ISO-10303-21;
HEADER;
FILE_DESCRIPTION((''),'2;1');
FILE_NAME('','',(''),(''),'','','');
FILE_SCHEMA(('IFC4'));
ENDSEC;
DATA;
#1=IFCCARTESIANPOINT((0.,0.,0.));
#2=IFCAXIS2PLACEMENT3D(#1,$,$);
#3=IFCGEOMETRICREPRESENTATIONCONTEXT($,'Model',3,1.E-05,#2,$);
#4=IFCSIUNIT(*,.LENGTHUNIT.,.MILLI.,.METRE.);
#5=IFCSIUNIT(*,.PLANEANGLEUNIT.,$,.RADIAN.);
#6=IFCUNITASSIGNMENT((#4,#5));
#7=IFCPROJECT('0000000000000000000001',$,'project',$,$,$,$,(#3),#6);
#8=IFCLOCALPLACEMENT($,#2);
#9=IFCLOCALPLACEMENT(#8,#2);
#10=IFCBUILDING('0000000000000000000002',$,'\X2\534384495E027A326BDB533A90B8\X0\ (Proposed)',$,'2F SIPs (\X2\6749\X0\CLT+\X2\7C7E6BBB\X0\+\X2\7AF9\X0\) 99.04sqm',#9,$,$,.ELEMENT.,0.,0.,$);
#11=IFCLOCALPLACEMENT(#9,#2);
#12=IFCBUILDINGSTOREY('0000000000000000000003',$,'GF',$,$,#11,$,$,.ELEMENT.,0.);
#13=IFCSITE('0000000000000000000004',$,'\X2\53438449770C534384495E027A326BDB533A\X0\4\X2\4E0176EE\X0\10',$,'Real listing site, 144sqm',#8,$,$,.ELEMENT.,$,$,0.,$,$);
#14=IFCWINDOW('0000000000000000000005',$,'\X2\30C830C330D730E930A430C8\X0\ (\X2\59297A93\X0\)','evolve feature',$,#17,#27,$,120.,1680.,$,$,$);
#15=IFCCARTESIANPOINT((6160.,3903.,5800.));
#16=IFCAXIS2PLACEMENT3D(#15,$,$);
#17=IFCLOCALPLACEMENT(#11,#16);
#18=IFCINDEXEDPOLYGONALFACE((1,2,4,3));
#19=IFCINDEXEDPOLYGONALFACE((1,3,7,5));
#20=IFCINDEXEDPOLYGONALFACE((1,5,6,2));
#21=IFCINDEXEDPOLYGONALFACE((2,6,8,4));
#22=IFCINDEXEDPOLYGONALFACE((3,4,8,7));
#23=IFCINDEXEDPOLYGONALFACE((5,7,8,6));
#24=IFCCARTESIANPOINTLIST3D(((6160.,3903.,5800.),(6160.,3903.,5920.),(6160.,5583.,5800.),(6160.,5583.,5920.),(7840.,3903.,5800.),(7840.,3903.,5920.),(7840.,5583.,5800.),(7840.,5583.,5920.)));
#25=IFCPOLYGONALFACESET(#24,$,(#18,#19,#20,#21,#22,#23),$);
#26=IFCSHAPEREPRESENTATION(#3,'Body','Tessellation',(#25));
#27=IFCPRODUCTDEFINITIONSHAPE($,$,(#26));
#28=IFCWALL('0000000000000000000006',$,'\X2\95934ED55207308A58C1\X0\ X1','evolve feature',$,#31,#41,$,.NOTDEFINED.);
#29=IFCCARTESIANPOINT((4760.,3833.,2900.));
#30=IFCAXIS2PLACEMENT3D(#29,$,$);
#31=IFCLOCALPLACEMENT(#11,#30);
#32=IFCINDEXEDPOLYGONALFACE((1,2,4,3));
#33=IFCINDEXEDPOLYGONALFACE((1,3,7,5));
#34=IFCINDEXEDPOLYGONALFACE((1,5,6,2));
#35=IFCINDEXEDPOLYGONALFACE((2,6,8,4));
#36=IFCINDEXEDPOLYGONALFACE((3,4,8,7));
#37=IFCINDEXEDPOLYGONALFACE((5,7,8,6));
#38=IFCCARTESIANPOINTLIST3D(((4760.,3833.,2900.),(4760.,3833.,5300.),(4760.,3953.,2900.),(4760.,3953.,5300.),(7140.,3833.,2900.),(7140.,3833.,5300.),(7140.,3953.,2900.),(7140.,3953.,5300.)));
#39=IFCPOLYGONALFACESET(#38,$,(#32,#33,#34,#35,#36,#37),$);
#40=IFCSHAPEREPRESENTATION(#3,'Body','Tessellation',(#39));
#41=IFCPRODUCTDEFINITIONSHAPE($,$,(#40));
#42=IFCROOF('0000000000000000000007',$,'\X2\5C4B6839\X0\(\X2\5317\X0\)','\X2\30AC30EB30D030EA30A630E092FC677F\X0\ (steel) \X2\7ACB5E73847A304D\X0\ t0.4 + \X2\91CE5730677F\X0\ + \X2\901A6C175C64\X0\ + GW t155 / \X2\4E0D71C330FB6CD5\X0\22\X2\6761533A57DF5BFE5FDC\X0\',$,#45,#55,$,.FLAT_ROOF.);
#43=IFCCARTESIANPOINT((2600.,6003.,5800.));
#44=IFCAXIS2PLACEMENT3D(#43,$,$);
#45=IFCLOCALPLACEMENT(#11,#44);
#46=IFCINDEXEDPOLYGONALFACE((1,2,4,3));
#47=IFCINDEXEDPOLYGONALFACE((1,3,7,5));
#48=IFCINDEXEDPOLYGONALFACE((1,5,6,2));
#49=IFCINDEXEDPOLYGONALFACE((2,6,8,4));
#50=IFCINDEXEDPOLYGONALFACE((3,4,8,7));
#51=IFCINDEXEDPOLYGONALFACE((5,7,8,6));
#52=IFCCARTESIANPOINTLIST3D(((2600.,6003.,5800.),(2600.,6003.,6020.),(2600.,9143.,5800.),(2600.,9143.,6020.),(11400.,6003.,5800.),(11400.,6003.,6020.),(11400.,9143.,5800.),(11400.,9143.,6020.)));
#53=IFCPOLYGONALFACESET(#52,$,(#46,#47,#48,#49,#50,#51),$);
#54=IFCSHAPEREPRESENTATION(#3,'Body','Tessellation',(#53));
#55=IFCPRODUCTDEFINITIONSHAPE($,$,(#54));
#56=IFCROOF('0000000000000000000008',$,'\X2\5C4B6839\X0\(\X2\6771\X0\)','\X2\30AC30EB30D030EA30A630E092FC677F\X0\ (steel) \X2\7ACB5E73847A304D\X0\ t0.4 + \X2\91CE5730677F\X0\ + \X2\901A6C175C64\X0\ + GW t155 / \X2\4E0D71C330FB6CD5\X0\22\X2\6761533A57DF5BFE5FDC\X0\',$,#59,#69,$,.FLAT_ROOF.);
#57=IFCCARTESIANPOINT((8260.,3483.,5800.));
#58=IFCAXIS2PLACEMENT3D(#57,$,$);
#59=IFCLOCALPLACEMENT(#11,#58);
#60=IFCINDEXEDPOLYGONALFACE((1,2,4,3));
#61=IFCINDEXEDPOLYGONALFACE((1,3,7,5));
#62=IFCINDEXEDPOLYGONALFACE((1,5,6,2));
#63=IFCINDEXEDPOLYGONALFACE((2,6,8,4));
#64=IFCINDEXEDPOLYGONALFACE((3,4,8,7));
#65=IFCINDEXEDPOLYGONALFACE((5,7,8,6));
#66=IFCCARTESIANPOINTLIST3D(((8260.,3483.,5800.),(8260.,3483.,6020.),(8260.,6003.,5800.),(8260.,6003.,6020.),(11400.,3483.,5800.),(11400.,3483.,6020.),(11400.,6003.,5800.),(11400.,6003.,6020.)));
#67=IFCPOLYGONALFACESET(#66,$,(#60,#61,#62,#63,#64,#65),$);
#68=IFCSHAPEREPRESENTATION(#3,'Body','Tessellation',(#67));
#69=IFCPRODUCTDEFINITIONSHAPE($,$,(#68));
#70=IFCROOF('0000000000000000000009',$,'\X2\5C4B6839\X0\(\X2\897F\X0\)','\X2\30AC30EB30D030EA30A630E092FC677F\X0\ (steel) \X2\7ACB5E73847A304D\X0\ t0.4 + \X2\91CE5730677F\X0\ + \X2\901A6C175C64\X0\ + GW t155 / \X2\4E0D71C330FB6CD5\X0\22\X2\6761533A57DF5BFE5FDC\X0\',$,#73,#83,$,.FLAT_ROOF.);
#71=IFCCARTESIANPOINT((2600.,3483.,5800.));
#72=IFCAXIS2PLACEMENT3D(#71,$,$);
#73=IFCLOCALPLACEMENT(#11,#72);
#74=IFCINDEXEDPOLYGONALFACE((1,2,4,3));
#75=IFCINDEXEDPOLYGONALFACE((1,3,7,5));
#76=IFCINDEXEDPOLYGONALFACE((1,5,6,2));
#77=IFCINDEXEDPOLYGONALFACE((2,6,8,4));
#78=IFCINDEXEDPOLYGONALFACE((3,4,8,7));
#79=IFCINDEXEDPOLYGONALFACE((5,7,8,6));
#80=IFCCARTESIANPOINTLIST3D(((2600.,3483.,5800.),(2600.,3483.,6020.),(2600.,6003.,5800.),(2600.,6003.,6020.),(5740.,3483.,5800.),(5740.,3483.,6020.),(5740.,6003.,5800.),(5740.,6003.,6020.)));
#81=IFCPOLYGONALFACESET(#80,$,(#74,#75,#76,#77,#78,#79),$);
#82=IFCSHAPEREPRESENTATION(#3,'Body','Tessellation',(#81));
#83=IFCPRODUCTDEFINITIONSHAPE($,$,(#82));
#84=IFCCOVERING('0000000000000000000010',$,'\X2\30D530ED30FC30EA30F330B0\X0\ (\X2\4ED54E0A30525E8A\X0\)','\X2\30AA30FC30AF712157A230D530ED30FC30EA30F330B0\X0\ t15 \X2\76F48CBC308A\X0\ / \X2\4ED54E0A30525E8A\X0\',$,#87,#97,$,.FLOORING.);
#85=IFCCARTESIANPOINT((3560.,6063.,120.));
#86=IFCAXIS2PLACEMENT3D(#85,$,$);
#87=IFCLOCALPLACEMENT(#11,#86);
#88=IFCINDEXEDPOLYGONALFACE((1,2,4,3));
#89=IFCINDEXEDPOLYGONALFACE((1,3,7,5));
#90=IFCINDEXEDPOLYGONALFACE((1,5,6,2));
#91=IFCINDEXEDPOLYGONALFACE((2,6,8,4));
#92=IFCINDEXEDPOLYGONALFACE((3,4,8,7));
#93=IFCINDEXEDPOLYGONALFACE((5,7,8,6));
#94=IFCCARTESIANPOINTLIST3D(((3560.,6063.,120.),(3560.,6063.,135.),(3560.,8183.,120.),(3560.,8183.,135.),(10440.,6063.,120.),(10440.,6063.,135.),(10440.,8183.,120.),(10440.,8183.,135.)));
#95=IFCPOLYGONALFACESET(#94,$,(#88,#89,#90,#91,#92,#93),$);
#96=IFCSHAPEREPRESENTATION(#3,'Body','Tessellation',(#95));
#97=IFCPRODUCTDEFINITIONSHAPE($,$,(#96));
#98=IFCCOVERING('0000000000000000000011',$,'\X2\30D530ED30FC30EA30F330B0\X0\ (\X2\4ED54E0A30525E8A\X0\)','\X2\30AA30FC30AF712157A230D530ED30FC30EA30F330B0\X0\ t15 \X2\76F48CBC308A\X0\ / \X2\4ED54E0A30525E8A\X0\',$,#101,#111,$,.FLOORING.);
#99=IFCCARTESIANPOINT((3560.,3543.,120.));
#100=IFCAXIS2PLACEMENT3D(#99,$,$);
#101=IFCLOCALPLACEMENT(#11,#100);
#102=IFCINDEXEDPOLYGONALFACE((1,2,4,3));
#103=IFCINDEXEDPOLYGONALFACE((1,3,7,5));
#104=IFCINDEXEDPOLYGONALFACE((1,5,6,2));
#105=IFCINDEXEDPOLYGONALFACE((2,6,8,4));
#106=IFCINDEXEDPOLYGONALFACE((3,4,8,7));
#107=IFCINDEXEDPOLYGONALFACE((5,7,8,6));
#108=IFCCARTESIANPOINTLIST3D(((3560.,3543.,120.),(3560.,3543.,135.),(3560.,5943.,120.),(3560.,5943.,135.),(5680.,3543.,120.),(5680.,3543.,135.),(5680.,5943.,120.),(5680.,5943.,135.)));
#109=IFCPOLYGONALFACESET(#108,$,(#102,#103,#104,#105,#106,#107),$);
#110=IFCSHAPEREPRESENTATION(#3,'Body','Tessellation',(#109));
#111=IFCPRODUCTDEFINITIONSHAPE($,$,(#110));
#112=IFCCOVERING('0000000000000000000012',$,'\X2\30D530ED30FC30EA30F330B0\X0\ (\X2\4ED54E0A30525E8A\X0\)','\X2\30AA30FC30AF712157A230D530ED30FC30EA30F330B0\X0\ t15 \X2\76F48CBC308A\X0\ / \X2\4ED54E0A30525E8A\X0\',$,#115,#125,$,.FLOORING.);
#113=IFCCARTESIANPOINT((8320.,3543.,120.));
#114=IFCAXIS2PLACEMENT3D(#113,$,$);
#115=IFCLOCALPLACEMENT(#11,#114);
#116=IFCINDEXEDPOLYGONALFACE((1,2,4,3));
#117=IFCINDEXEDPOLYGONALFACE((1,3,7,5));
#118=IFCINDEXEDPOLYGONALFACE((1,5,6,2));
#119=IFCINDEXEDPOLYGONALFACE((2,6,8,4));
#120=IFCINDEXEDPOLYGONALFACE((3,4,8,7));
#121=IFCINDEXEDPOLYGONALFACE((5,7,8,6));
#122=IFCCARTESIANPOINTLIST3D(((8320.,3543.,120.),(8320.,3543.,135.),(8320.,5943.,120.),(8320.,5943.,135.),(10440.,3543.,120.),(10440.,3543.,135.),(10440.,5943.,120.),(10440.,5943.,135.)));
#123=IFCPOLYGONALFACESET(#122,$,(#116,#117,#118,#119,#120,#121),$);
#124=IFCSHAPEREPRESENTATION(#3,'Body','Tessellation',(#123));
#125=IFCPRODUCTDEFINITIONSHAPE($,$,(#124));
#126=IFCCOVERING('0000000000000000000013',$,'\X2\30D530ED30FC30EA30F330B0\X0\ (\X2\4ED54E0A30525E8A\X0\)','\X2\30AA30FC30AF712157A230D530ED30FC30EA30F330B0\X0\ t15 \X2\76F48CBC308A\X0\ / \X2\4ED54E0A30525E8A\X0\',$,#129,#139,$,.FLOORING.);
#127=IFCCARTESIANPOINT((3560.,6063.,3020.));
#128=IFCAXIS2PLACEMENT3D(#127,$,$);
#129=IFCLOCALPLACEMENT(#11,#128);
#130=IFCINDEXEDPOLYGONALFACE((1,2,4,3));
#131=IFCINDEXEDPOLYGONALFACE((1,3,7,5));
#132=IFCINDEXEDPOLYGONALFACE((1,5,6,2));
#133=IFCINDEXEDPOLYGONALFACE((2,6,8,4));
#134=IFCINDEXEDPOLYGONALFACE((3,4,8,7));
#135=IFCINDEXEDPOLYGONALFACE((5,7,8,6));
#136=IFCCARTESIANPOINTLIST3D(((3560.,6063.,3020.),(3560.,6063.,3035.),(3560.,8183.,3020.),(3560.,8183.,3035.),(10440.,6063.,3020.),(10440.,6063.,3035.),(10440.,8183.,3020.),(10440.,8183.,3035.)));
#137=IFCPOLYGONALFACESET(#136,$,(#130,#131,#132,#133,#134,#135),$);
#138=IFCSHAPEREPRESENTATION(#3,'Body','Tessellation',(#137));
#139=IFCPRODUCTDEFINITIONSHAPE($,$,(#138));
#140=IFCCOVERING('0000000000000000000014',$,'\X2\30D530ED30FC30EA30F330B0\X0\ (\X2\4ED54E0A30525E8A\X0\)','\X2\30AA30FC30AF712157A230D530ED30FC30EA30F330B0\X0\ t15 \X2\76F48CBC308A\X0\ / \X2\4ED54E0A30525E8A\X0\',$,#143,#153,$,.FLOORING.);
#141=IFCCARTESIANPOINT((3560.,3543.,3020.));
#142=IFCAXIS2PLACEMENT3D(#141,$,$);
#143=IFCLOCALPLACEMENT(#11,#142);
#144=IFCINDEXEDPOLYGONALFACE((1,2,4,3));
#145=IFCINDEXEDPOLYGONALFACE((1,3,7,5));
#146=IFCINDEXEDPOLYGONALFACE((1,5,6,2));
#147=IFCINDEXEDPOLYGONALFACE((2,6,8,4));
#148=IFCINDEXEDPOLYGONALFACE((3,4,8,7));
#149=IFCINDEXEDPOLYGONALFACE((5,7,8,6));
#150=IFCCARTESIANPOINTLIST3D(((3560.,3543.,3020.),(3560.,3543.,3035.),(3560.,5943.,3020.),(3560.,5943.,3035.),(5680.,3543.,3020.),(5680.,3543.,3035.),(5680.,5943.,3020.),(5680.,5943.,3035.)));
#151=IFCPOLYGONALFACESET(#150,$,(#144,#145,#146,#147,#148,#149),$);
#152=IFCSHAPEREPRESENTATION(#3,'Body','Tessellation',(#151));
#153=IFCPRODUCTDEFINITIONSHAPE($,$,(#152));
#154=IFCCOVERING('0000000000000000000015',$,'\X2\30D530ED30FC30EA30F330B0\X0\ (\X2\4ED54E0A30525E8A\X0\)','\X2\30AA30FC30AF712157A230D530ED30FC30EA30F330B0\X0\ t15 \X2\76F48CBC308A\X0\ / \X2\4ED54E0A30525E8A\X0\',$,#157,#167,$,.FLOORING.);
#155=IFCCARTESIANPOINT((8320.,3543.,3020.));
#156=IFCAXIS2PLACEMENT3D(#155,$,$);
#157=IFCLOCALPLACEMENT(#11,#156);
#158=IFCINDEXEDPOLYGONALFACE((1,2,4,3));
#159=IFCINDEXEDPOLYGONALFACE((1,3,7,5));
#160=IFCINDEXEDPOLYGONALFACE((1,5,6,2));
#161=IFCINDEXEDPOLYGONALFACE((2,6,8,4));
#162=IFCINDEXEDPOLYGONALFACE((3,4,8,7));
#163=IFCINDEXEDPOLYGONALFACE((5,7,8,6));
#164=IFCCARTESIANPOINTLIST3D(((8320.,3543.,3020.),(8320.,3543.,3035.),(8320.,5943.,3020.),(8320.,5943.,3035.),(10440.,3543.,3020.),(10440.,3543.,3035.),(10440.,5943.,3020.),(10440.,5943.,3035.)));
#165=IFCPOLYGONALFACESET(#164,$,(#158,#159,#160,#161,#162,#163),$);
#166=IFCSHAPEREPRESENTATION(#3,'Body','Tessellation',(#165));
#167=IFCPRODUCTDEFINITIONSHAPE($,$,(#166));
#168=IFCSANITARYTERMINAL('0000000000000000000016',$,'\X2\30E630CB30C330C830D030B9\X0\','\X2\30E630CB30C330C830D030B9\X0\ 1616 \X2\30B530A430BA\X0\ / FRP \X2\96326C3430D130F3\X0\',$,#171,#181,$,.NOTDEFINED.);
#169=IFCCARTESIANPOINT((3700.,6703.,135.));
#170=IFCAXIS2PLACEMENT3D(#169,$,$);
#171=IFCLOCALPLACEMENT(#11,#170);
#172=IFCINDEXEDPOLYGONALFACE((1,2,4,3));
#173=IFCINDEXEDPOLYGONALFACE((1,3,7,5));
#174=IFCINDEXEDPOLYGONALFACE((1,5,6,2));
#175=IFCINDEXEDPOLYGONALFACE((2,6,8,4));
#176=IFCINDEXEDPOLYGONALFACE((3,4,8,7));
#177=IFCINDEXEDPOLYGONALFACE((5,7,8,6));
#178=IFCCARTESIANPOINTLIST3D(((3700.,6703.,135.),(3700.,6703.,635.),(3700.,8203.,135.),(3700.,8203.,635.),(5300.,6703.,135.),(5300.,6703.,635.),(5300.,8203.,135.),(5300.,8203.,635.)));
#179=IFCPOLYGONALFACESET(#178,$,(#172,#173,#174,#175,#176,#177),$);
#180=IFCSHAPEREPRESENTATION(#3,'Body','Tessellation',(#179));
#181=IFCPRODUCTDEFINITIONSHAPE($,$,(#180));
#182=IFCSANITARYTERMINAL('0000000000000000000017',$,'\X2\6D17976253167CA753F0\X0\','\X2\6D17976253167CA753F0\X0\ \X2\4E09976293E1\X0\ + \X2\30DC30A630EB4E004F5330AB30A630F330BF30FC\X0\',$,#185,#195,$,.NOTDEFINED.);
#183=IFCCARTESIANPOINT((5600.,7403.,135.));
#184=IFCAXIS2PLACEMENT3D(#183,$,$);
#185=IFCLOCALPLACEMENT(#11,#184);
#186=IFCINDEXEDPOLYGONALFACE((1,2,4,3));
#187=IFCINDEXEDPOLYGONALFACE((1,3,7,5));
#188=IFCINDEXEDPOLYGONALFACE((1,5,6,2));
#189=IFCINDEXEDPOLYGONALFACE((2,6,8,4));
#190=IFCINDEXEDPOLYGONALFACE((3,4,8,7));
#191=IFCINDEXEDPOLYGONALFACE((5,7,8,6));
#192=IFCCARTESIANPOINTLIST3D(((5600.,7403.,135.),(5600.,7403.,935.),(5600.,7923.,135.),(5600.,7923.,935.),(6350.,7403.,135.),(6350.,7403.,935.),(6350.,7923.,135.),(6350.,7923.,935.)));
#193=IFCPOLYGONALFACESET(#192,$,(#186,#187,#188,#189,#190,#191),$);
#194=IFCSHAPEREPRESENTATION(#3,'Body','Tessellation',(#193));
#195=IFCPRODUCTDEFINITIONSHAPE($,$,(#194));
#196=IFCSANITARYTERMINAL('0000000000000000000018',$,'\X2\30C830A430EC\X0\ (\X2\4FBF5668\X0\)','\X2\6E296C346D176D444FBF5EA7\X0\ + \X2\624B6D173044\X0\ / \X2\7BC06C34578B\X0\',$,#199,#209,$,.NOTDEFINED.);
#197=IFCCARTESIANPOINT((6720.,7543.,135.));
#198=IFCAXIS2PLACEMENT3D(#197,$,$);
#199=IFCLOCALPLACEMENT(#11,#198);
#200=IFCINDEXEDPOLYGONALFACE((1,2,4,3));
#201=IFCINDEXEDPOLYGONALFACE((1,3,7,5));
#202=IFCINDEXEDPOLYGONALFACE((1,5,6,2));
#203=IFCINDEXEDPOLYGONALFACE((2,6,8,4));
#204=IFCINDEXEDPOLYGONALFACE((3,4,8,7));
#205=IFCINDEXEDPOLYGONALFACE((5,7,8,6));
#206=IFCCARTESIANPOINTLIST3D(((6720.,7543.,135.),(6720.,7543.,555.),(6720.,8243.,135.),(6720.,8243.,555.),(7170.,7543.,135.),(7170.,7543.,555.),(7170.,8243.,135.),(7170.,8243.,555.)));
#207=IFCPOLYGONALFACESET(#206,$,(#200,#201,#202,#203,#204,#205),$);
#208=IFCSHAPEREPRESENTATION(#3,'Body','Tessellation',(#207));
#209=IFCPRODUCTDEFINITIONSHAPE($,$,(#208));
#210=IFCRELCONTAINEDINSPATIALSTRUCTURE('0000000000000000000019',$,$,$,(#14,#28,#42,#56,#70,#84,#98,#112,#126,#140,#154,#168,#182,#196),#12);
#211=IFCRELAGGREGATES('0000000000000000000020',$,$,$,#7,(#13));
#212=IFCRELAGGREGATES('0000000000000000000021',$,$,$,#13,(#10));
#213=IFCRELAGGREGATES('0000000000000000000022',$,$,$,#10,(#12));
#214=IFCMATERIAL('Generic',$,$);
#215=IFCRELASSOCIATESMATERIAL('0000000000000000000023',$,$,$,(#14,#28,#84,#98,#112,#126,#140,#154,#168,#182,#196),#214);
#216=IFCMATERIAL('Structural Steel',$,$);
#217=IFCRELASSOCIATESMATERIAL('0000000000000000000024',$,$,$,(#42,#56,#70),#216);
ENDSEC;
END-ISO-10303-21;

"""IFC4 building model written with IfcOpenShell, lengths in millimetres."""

from ifc_helpers import new_model, si_unit, frame, frame_2d, origin, place, context, project, spatial, rectangle, extrude, material, element, save


model = new_model("IFC4")

# Units and contexts
model_context = context("Model", 3, precision=1e-05, world=origin())
ifc_project = project(units=[si_unit("LENGTHUNIT", "METRE", prefix="MILLI"), si_unit("PLANEANGLEUNIT", "RADIAN")], contexts=[model_context])

# Site, building, storey
site_placement = place(None, origin())
site = spatial("IfcSite", under=ifc_project, at=site_placement, Name="千葉県千葉市稲毛区4丁目10", ObjectType="Real listing site, 144sqm", CompositionType="ELEMENT", RefElevation=0.0)
building_placement = place(site_placement, origin())
building = spatial("IfcBuilding", under=site, at=building_placement, Name="千葉市稲毛区邸 (Proposed)", ObjectType="2F SIPs (杉CLT+籾殻+竹) 99.04sqm", CompositionType="ELEMENT", ElevationOfRefHeight=0.0, ElevationOfTerrain=0.0)
storey_placement = place(building_placement, origin())
storey = spatial("IfcBuildingStorey", under=building, at=storey_placement, Name="GF", CompositionType="ELEMENT", Elevation=0.0)

# Window
ifc_material_1 = material(Name="Generic")
window_1_placement = place(storey_placement, frame((6160.0, 3903.0, 5800.0)))
element("IfcWindow", 1, at=window_1_placement, inside=storey, material=ifc_material_1, Name="トップライト (天窓)", Description="evolve feature", OverallHeight=120.0, OverallWidth=1680.0, context=model_context, shape_type="SweptSolid", body=[
    extrude(rectangle(XDim=1680.0, YDim=1680.0, at=frame_2d((840.0, 840.0))), frame((6160.0, 3903.0, 5800.0)), (0.0, 0.0, 1.0), 120.0),
])

# Wall
wall_1_placement = place(storey_placement, frame((4760.0, 3833.0, 2900.0)))
element("IfcWall", 2, at=wall_1_placement, inside=storey, material=ifc_material_1, Name="間仕切り壁 X1", Description="evolve feature", PredefinedType="NOTDEFINED", context=model_context, shape_type="SweptSolid", body=[
    extrude(rectangle(XDim=2380.0, YDim=120.0, at=frame_2d((1190.0, 60.0))), frame((4760.0, 3833.0, 2900.0)), (0.0, 0.0, 1.0), 2400.0),
])

# Roofs
ifc_material_2 = material(Name="Structural Steel")
roof_1_placement = place(storey_placement, frame((2600.0, 6003.0, 5800.0)))
element("IfcRoof", 3, at=roof_1_placement, inside=storey, material=ifc_material_2, Name="屋根(北)", Description="ガルバリウム鋼板 (steel) 立平葺き t0.4 + 野地板 + 通気層 + GW t155 / 不燃・法22条区域対応", PredefinedType="FLAT_ROOF", context=model_context, shape_type="SweptSolid", body=[
    extrude(rectangle(XDim=8800.0, YDim=3140.0, at=frame_2d((4400.0, 1570.0))), frame((2600.0, 6003.0, 5800.0)), (0.0, 0.0, 1.0), 220.0),
])
roof_2_placement = place(storey_placement, frame((8260.0, 3483.0, 5800.0)))
element("IfcRoof", 4, at=roof_2_placement, inside=storey, material=ifc_material_2, Name="屋根(東)", Description="ガルバリウム鋼板 (steel) 立平葺き t0.4 + 野地板 + 通気層 + GW t155 / 不燃・法22条区域対応", PredefinedType="FLAT_ROOF", context=model_context, shape_type="SweptSolid", body=[
    extrude(rectangle(XDim=3140.0, YDim=2520.0, at=frame_2d((1570.0, 1260.0))), frame((8260.0, 3483.0, 5800.0)), (0.0, 0.0, 1.0), 220.0),
])
roof_3_placement = place(storey_placement, frame((2600.0, 3483.0, 5800.0)))
element("IfcRoof", 5, at=roof_3_placement, inside=storey, material=ifc_material_2, Name="屋根(西)", Description="ガルバリウム鋼板 (steel) 立平葺き t0.4 + 野地板 + 通気層 + GW t155 / 不燃・法22条区域対応", PredefinedType="FLAT_ROOF", context=model_context, shape_type="SweptSolid", body=[
    extrude(rectangle(XDim=3140.0, YDim=2520.0, at=frame_2d((1570.0, 1260.0))), frame((2600.0, 3483.0, 5800.0)), (0.0, 0.0, 1.0), 220.0),
])

# Coverings
covering_1_placement = place(storey_placement, frame((3560.0, 6063.0, 120.0)))
element("IfcCovering", 6, at=covering_1_placement, inside=storey, material=ifc_material_1, Name="フローリング (仕上げ床)", Description="オーク無垢フローリング t15 直貼り / 仕上げ床", PredefinedType="FLOORING", context=model_context, shape_type="SweptSolid", body=[
    extrude(rectangle(XDim=6880.0, YDim=2120.0, at=frame_2d((3440.0, 1060.0))), frame((3560.0, 6063.0, 120.0)), (0.0, 0.0, 1.0), 15.0),
])
covering_2_placement = place(storey_placement, frame((3560.0, 3543.0, 120.0)))
element("IfcCovering", 7, at=covering_2_placement, inside=storey, material=ifc_material_1, Name="フローリング (仕上げ床)", Description="オーク無垢フローリング t15 直貼り / 仕上げ床", PredefinedType="FLOORING", context=model_context, shape_type="SweptSolid", body=[
    extrude(rectangle(XDim=2120.0, YDim=2400.0, at=frame_2d((1060.0, 1200.0))), frame((3560.0, 3543.0, 120.0)), (0.0, 0.0, 1.0), 15.0),
])
covering_3_placement = place(storey_placement, frame((8320.0, 3543.0, 120.0)))
element("IfcCovering", 8, at=covering_3_placement, inside=storey, material=ifc_material_1, Name="フローリング (仕上げ床)", Description="オーク無垢フローリング t15 直貼り / 仕上げ床", PredefinedType="FLOORING", context=model_context, shape_type="SweptSolid", body=[
    extrude(rectangle(XDim=2120.0, YDim=2400.0, at=frame_2d((1060.0, 1200.0))), frame((8320.0, 3543.0, 120.0)), (0.0, 0.0, 1.0), 15.0),
])
covering_4_placement = place(storey_placement, frame((3560.0, 6063.0, 3020.0)))
element("IfcCovering", 9, at=covering_4_placement, inside=storey, material=ifc_material_1, Name="フローリング (仕上げ床)", Description="オーク無垢フローリング t15 直貼り / 仕上げ床", PredefinedType="FLOORING", context=model_context, shape_type="SweptSolid", body=[
    extrude(rectangle(XDim=6880.0, YDim=2120.0, at=frame_2d((3440.0, 1060.0))), frame((3560.0, 6063.0, 3020.0)), (0.0, 0.0, 1.0), 15.0),
])
covering_5_placement = place(storey_placement, frame((3560.0, 3543.0, 3020.0)))
element("IfcCovering", 10, at=covering_5_placement, inside=storey, material=ifc_material_1, Name="フローリング (仕上げ床)", Description="オーク無垢フローリング t15 直貼り / 仕上げ床", PredefinedType="FLOORING", context=model_context, shape_type="SweptSolid", body=[
    extrude(rectangle(XDim=2120.0, YDim=2400.0, at=frame_2d((1060.0, 1200.0))), frame((3560.0, 3543.0, 3020.0)), (0.0, 0.0, 1.0), 15.0),
])
covering_6_placement = place(storey_placement, frame((8320.0, 3543.0, 3020.0)))
element("IfcCovering", 11, at=covering_6_placement, inside=storey, material=ifc_material_1, Name="フローリング (仕上げ床)", Description="オーク無垢フローリング t15 直貼り / 仕上げ床", PredefinedType="FLOORING", context=model_context, shape_type="SweptSolid", body=[
    extrude(rectangle(XDim=2120.0, YDim=2400.0, at=frame_2d((1060.0, 1200.0))), frame((8320.0, 3543.0, 3020.0)), (0.0, 0.0, 1.0), 15.0),
])

# Sanitary terminals
sanitary_terminal_1_placement = place(storey_placement, frame((3700.0, 6703.0, 135.0)))
element("IfcSanitaryTerminal", 12, at=sanitary_terminal_1_placement, inside=storey, material=ifc_material_1, Name="ユニットバス", Description="ユニットバス 1616 サイズ / FRP 防水パン", PredefinedType="NOTDEFINED", context=model_context, shape_type="SweptSolid", body=[
    extrude(rectangle(XDim=1600.0, YDim=1500.0, at=frame_2d((800.0, 750.0))), frame((3700.0, 6703.0, 135.0)), (0.0, 0.0, 1.0), 500.0),
])
sanitary_terminal_2_placement = place(storey_placement, frame((5600.0, 7403.0, 135.0)))
element("IfcSanitaryTerminal", 13, at=sanitary_terminal_2_placement, inside=storey, material=ifc_material_1, Name="洗面化粧台", Description="洗面化粧台 三面鏡 + ボウル一体カウンター", PredefinedType="NOTDEFINED", context=model_context, shape_type="SweptSolid", body=[
    extrude(rectangle(XDim=750.0, YDim=520.0, at=frame_2d((375.0, 260.0))), frame((5600.0, 7403.0, 135.0)), (0.0, 0.0, 1.0), 800.0),
])
sanitary_terminal_3_placement = place(storey_placement, frame((6720.0, 7543.0, 135.0)))
element("IfcSanitaryTerminal", 14, at=sanitary_terminal_3_placement, inside=storey, material=ifc_material_1, Name="トイレ (便器)", Description="温水洗浄便座 + 手洗い / 節水型", PredefinedType="NOTDEFINED", context=model_context, shape_type="SweptSolid", body=[
    extrude(rectangle(XDim=450.0, YDim=700.0, at=frame_2d((225.0, 350.0))), frame((6720.0, 7543.0, 135.0)), (0.0, 0.0, 1.0), 420.0),
])

save(model, "model.ifc")
